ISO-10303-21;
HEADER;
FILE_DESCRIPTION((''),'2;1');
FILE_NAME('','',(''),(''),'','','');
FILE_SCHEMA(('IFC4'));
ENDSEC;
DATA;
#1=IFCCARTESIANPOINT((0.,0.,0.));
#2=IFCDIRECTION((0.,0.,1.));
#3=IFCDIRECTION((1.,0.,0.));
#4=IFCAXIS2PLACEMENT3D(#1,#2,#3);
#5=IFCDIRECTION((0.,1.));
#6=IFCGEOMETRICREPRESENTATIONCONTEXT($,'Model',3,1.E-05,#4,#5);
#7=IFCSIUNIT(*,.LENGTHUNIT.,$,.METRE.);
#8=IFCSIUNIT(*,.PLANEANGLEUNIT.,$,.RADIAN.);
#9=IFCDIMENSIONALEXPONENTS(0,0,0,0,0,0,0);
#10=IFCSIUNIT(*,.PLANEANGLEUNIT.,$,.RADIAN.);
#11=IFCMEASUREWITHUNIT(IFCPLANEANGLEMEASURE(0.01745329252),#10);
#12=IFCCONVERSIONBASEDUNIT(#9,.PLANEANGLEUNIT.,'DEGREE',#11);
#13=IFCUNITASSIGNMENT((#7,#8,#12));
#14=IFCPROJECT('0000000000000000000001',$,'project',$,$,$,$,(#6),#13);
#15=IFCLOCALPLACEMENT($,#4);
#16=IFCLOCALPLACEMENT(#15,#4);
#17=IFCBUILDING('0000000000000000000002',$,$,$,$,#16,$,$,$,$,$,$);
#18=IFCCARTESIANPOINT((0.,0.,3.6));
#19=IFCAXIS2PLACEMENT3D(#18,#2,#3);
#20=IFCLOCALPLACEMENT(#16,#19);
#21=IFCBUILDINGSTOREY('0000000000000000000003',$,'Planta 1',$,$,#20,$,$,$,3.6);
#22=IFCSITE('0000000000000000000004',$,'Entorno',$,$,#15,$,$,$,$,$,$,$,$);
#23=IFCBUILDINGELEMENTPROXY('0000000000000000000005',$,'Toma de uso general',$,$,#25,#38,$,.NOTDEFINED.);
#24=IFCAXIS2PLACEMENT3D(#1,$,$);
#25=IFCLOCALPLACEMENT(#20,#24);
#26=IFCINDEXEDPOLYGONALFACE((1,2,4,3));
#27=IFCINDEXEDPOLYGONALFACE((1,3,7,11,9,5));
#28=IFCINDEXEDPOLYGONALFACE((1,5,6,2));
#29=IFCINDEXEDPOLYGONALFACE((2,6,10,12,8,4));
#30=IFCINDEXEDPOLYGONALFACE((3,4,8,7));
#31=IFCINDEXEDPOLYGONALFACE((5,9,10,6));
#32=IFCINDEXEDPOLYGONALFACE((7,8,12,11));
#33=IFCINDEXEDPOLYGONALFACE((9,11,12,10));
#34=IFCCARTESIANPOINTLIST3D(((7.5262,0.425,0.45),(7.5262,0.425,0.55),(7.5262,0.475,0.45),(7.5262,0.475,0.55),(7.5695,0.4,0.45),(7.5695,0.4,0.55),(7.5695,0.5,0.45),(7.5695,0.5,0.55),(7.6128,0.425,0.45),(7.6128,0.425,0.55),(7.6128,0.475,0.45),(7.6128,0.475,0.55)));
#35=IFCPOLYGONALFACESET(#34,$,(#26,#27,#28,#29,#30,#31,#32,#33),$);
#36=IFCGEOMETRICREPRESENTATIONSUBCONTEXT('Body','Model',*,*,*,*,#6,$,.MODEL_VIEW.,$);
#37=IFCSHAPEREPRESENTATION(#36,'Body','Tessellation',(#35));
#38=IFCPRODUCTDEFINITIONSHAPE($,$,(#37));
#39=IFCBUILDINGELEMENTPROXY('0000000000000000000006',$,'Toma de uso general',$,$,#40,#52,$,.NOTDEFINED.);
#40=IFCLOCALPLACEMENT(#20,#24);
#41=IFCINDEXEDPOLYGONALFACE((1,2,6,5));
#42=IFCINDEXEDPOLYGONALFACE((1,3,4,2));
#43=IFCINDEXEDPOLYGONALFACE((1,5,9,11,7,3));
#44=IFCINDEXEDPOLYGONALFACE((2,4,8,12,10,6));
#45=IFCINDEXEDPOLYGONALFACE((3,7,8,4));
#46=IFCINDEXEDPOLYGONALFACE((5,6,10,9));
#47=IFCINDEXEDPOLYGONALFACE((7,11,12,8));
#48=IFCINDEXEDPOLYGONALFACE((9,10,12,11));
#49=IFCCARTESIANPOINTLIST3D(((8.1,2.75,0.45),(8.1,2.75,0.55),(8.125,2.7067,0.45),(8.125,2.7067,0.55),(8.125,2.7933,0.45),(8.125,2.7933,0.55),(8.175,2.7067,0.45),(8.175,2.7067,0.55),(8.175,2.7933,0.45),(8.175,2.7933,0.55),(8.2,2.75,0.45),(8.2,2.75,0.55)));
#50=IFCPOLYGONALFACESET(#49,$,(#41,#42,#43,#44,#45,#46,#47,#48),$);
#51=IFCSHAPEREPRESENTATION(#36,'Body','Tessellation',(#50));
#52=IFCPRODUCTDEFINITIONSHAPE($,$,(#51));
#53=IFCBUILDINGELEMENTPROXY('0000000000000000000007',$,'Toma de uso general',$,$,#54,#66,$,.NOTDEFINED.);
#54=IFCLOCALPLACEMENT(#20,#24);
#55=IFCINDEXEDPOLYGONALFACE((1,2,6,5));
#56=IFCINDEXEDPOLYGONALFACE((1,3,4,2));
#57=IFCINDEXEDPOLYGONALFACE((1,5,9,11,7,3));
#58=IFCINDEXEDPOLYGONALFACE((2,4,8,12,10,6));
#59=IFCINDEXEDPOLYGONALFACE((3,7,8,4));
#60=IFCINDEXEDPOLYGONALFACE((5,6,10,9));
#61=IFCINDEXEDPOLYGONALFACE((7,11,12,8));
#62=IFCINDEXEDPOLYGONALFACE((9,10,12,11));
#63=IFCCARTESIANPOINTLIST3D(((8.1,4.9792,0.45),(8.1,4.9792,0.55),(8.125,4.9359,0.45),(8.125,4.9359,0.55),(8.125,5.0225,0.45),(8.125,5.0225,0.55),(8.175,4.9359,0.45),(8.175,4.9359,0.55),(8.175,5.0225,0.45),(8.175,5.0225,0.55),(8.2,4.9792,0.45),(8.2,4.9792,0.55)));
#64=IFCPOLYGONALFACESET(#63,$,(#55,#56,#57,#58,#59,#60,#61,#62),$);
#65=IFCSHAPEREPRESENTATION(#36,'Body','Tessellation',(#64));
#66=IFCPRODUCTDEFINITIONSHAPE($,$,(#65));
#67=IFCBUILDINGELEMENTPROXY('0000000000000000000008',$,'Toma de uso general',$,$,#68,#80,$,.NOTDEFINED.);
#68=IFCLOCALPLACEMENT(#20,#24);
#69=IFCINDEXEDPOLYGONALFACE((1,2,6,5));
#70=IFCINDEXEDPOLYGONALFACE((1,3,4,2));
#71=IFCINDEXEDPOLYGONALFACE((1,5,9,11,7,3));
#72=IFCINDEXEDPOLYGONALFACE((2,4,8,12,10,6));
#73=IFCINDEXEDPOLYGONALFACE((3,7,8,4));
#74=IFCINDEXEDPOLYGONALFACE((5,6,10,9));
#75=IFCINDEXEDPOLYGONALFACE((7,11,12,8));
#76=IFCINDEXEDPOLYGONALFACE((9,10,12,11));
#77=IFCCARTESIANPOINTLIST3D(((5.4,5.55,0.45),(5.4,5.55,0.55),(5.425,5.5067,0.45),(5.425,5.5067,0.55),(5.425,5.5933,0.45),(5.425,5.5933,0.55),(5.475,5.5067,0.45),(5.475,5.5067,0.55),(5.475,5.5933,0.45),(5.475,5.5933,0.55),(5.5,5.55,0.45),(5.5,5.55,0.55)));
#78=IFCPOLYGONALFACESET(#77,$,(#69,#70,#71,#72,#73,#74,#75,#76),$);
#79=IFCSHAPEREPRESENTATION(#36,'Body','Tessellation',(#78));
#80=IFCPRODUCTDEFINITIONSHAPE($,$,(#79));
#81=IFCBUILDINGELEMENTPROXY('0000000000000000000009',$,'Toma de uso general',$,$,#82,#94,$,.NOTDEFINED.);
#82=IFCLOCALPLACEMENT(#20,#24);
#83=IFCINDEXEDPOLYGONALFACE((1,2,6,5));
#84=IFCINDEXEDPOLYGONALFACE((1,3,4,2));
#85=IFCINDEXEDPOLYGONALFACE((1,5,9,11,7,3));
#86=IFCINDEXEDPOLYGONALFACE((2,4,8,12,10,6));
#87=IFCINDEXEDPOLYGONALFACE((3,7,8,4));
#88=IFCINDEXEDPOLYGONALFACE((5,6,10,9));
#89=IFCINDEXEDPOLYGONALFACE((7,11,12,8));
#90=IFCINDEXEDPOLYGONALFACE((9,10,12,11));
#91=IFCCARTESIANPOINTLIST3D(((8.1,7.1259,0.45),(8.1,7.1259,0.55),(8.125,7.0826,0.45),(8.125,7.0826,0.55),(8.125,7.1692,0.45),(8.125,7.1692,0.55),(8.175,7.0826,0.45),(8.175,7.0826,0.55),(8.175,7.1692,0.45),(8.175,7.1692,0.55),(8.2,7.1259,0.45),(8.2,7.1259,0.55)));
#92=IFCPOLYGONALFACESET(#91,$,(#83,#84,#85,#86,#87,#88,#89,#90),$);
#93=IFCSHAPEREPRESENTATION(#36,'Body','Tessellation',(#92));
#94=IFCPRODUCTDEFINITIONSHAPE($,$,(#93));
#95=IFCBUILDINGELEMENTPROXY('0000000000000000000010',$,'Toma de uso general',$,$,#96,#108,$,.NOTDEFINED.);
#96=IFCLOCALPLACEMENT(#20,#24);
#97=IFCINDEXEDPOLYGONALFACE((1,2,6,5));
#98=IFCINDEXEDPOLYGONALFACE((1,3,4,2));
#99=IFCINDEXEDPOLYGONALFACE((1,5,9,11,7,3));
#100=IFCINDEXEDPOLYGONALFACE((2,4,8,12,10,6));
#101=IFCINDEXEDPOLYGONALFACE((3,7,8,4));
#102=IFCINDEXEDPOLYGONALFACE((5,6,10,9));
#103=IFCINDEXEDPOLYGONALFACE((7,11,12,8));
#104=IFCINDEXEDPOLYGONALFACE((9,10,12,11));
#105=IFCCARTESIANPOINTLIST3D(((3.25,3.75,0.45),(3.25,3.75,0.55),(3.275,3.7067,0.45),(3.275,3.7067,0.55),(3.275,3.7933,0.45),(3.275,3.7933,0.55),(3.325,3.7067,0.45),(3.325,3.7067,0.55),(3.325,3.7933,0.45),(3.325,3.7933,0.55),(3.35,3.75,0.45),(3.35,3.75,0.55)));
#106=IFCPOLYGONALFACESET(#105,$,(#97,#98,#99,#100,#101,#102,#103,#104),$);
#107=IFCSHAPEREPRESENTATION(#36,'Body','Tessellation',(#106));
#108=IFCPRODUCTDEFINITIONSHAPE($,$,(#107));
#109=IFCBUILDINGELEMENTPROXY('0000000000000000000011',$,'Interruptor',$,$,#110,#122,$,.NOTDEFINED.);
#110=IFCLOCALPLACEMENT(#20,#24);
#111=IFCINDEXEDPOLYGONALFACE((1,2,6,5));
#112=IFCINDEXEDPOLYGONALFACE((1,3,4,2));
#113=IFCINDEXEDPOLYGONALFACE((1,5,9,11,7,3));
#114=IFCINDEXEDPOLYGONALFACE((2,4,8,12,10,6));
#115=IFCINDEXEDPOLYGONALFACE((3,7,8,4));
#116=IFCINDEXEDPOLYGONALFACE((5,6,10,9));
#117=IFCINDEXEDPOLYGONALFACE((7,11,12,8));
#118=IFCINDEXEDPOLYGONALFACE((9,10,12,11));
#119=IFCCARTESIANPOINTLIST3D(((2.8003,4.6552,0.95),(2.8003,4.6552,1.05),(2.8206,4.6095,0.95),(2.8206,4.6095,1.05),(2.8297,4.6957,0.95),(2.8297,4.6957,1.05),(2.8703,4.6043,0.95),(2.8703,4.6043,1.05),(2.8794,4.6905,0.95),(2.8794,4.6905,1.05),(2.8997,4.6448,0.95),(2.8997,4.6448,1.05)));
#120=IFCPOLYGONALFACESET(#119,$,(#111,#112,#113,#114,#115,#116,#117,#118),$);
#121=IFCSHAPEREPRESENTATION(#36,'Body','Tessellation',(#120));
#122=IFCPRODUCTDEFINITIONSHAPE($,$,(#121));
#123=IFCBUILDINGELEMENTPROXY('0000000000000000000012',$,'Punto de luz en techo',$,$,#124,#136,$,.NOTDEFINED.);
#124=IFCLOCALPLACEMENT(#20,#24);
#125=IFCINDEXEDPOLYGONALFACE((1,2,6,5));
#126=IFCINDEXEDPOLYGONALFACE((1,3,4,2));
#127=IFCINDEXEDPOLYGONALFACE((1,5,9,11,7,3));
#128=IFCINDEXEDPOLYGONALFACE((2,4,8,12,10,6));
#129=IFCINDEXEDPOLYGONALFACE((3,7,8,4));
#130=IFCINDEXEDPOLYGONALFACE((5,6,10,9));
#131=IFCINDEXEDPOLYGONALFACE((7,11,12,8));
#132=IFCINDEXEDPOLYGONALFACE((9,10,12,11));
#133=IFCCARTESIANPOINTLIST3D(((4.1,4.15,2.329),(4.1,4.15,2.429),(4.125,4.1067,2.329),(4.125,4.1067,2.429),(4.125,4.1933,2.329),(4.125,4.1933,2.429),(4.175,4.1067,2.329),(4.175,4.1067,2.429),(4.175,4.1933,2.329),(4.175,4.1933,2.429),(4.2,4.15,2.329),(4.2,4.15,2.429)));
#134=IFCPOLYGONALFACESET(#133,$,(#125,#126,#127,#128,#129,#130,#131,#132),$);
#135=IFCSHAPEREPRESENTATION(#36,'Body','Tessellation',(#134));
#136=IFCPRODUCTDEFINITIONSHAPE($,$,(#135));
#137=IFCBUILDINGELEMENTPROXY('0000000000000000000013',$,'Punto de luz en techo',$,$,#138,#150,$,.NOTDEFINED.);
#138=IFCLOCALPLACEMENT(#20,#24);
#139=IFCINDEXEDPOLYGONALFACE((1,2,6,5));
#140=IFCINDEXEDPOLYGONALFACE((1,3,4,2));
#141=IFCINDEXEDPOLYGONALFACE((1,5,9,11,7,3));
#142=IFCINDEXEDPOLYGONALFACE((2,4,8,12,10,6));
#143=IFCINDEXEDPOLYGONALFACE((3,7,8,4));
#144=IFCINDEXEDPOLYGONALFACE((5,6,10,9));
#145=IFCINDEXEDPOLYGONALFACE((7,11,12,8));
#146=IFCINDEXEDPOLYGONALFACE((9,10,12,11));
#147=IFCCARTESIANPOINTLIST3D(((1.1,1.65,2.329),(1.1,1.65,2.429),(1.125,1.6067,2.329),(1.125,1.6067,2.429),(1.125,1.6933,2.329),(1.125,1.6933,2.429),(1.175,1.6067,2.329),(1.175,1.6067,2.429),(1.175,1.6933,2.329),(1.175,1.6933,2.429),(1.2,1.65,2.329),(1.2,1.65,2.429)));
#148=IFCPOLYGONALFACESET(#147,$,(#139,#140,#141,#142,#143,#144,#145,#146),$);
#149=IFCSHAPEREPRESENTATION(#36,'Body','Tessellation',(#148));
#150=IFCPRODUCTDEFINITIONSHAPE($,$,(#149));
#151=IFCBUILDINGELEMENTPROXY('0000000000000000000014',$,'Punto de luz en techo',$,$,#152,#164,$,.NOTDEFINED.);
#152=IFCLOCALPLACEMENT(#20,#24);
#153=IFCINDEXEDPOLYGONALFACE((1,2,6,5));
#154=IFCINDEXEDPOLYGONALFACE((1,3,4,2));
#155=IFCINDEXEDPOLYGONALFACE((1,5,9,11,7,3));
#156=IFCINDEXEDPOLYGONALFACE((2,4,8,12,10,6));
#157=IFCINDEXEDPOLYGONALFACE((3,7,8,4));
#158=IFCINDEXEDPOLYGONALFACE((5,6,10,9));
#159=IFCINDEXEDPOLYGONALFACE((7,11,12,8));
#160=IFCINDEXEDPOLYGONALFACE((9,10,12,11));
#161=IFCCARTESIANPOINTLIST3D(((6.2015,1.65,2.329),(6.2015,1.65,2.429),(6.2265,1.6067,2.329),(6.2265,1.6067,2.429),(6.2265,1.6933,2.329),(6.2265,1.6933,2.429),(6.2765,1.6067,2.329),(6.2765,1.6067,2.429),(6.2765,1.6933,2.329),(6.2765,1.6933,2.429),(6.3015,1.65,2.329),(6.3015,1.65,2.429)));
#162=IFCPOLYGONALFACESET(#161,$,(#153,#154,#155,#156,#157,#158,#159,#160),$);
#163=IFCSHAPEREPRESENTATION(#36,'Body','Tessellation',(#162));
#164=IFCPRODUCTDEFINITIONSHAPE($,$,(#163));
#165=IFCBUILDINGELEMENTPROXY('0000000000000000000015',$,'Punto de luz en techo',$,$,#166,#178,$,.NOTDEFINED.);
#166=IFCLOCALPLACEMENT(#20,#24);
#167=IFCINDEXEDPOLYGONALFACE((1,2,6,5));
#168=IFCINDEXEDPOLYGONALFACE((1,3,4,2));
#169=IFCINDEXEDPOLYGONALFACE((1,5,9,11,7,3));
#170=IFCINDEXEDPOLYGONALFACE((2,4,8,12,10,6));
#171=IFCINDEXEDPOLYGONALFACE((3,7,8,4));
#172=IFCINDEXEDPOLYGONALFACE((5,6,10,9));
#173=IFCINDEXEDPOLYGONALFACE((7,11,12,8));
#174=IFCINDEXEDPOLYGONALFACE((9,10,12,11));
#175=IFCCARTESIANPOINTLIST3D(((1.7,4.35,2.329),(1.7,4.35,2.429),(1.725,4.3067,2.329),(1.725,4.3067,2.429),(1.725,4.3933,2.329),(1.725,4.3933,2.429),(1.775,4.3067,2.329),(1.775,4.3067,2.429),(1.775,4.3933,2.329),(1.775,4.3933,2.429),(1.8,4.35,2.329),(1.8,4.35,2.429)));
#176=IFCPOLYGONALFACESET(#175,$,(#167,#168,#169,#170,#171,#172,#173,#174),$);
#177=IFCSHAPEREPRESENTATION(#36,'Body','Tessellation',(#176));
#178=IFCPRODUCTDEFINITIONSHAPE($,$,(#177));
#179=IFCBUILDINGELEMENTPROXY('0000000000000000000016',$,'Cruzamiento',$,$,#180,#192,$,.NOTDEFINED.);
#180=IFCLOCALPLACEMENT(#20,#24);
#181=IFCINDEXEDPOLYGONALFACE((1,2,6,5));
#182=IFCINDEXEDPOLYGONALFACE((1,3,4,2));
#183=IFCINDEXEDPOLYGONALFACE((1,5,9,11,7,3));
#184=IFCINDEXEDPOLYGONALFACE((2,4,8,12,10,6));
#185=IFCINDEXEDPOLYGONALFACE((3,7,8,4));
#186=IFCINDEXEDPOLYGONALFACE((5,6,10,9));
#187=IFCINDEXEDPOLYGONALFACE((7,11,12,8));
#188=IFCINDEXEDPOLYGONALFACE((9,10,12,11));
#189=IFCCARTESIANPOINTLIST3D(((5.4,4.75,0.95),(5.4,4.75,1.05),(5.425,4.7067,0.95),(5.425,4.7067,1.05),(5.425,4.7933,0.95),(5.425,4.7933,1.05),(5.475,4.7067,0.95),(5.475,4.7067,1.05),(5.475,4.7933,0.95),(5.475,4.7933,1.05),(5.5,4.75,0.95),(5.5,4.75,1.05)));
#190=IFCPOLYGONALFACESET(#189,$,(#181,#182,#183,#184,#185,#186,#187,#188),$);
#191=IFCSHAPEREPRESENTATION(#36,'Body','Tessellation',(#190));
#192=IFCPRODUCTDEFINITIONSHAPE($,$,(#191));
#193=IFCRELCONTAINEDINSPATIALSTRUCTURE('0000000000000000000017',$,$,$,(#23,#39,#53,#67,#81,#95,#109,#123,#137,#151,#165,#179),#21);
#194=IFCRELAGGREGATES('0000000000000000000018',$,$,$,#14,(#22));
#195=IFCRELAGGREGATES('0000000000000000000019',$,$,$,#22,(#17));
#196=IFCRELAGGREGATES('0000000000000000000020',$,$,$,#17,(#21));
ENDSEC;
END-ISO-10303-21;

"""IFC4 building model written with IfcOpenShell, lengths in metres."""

from ifc_helpers import new_model, entity, si_unit, converted_unit, direction, frame, origin_with_axes, place, context, subcontext, project, spatial, polyline, outline, extrude, source, transform, mapped, element, save


model = new_model("IFC4")

# Units and contexts
model_context = context("Model", 3, precision=1e-05, world=origin_with_axes(), true_north=direction((0.0, 1.0)))
body_context = subcontext(model_context, "Body", "Model", "MODEL_VIEW")
ifc_project = project(units=[si_unit("LENGTHUNIT", "METRE"), si_unit("PLANEANGLEUNIT", "RADIAN"), converted_unit("PLANEANGLEUNIT", "DEGREE", entity("IfcPlaneAngleMeasure", 0.01745329252), si_unit("PLANEANGLEUNIT", "RADIAN"), dimensions=[0, 0, 0, 0, 0, 0, 0])], contexts=[model_context])

# Site, building, storey
site_placement = place(None, origin_with_axes())
site = spatial("IfcSite", under=ifc_project, at=site_placement, Name="Entorno")
building_placement = place(site_placement, origin_with_axes())
building = spatial("IfcBuilding", under=site, at=building_placement)
storey_placement = place(building_placement, frame((0.0, 0.0, 3.6), z_axis=(0.0, 0.0, 1.0), x_axis=(1.0, 0.0, 0.0)))
storey = spatial("IfcBuildingStorey", under=building, at=storey_placement, Name="Planta 1", Elevation=3.6)

# Building element proxies
shared_shape_1 = source(origin_with_axes(), body_context, "Body", "SolidModel", [
    extrude(outline(polyline([(0.05, 0.0), (0.025, 0.0433), (-0.025, 0.0433), (-0.05, 0.0), (-0.025, -0.0433), (0.025, -0.0433), (0.05, 0.0)])), frame((0.0, 0.0, -0.05), z_axis=(0.0, 0.0, 1.0), x_axis=(1.0, 0.0, 0.0)), (0.0, 0.0, 1.0), 0.1),
])
proxy_1_placement = place(storey_placement, frame((0.0, 0.0, -3.6), z_axis=(0.0, 0.0, 1.0), x_axis=(1.0, 0.0, 0.0)))
element("IfcBuildingElementProxy", 1, at=proxy_1_placement, inside=storey, Name="Toma de uso general", PredefinedType="NOTDEFINED", context=body_context, shape_type="Brep", body=[
    mapped(shared_shape_1, transform((7.5695, 0.45, 4.1), x_axis=(0.0, 1.0, 0.0), y_axis=(-1.0, 0.0, 0.0), z_axis=(0.0, 0.0, 1.0))),
])
proxy_2_placement = place(storey_placement, frame((0.0, 0.0, -3.6), z_axis=(0.0, 0.0, 1.0), x_axis=(1.0, 0.0, 0.0)))
element("IfcBuildingElementProxy", 2, at=proxy_2_placement, inside=storey, Name="Toma de uso general", PredefinedType="NOTDEFINED", context=body_context, shape_type="Brep", body=[
    mapped(shared_shape_1, transform((8.15, 2.75, 4.1), x_axis=(-1.0, 0.0, 0.0), y_axis=(0.0, -1.0, 0.0), z_axis=(0.0, 0.0, 1.0))),
])
proxy_3_placement = place(storey_placement, frame((0.0, 0.0, -3.6), z_axis=(0.0, 0.0, 1.0), x_axis=(1.0, 0.0, 0.0)))
element("IfcBuildingElementProxy", 3, at=proxy_3_placement, inside=storey, Name="Toma de uso general", PredefinedType="NOTDEFINED", context=body_context, shape_type="Brep", body=[
    mapped(shared_shape_1, transform((8.15, 4.9792, 4.1), x_axis=(-1.0, 0.0, 0.0), y_axis=(0.0, -1.0, 0.0), z_axis=(0.0, 0.0, 1.0))),
])
proxy_4_placement = place(storey_placement, frame((0.0, 0.0, -3.6), z_axis=(0.0, 0.0, 1.0), x_axis=(1.0, 0.0, 0.0)))
element("IfcBuildingElementProxy", 4, at=proxy_4_placement, inside=storey, Name="Toma de uso general", PredefinedType="NOTDEFINED", context=body_context, shape_type="Brep", body=[
    mapped(shared_shape_1, transform((5.45, 5.55, 4.1), x_axis=(1.0, 0.0, 0.0), y_axis=(0.0, 1.0, 0.0), z_axis=(0.0, 0.0, 1.0))),
])
proxy_5_placement = place(storey_placement, frame((0.0, 0.0, -3.6), z_axis=(0.0, 0.0, 1.0), x_axis=(1.0, 0.0, 0.0)))
element("IfcBuildingElementProxy", 5, at=proxy_5_placement, inside=storey, Name="Toma de uso general", PredefinedType="NOTDEFINED", context=body_context, shape_type="Brep", body=[
    mapped(shared_shape_1, transform((8.15, 7.1259, 4.1), x_axis=(-1.0, 0.0, 0.0), y_axis=(0.0, -1.0, 0.0), z_axis=(0.0, 0.0, 1.0))),
])
proxy_6_placement = place(storey_placement, frame((0.0, 0.0, -3.6), z_axis=(0.0, 0.0, 1.0), x_axis=(1.0, 0.0, 0.0)))
element("IfcBuildingElementProxy", 6, at=proxy_6_placement, inside=storey, Name="Toma de uso general", PredefinedType="NOTDEFINED", context=body_context, shape_type="Brep", body=[
    mapped(shared_shape_1, transform((3.3, 3.75, 4.1), x_axis=(1.0, 0.0, 0.0), y_axis=(0.0, 1.0, 0.0), z_axis=(0.0, 0.0, 1.0))),
])
shared_shape_2 = source(origin_with_axes(), body_context, "Body", "SolidModel", [
    extrude(outline(polyline([(0.05, 0.0), (0.025, 0.0433), (-0.025, 0.0433), (-0.05, 0.0), (-0.025, -0.0433), (0.025, -0.0433), (0.05, 0.0)])), frame((0.0, 0.0, -0.05), z_axis=(0.0, 0.0, 1.0), x_axis=(1.0, 0.0, 0.0)), (0.0, 0.0, 1.0), 0.1),
])
proxy_7_placement = place(storey_placement, frame((0.0, 0.0, -3.6), z_axis=(0.0, 0.0, 1.0), x_axis=(1.0, 0.0, 0.0)))
element("IfcBuildingElementProxy", 7, at=proxy_7_placement, inside=storey, Name="Interruptor", PredefinedType="NOTDEFINED", context=body_context, shape_type="Brep", body=[
    mapped(shared_shape_2, transform((2.85, 4.65, 4.6), x_axis=(-0.406737, 0.913545, 0.0), y_axis=(-0.913545, -0.406737, 0.0), z_axis=(0.0, 0.0, 1.0))),
])
shared_shape_3 = source(origin_with_axes(), body_context, "Body", "SolidModel", [
    extrude(outline(polyline([(0.05, 0.0), (0.025, 0.0433), (-0.025, 0.0433), (-0.05, 0.0), (-0.025, -0.0433), (0.025, -0.0433), (0.05, 0.0)])), frame((0.0, 0.0, -0.05), z_axis=(0.0, 0.0, 1.0), x_axis=(1.0, 0.0, 0.0)), (0.0, 0.0, 1.0), 0.1),
])
proxy_8_placement = place(storey_placement, frame((0.0, 0.0, -3.6), z_axis=(0.0, 0.0, 1.0), x_axis=(1.0, 0.0, 0.0)))
element("IfcBuildingElementProxy", 8, at=proxy_8_placement, inside=storey, Name="Punto de luz en techo", PredefinedType="NOTDEFINED", context=body_context, shape_type="Brep", body=[
    mapped(shared_shape_3, transform((4.15, 4.15, 5.979), x_axis=(1.0, 0.0, 0.0), y_axis=(0.0, 1.0, 0.0), z_axis=(0.0, 0.0, 1.0))),
])
proxy_9_placement = place(storey_placement, frame((0.0, 0.0, -3.6), z_axis=(0.0, 0.0, 1.0), x_axis=(1.0, 0.0, 0.0)))
element("IfcBuildingElementProxy", 9, at=proxy_9_placement, inside=storey, Name="Punto de luz en techo", PredefinedType="NOTDEFINED", context=body_context, shape_type="Brep", body=[
    mapped(shared_shape_3, transform((1.15, 1.65, 5.979), x_axis=(1.0, 0.0, 0.0), y_axis=(0.0, 1.0, 0.0), z_axis=(0.0, 0.0, 1.0))),
])
proxy_10_placement = place(storey_placement, frame((0.0, 0.0, -3.6), z_axis=(0.0, 0.0, 1.0), x_axis=(1.0, 0.0, 0.0)))
element("IfcBuildingElementProxy", 10, at=proxy_10_placement, inside=storey, Name="Punto de luz en techo", PredefinedType="NOTDEFINED", context=body_context, shape_type="Brep", body=[
    mapped(shared_shape_3, transform((6.2515, 1.65, 5.979), x_axis=(1.0, 0.0, 0.0), y_axis=(0.0, 1.0, 0.0), z_axis=(0.0, 0.0, 1.0))),
])
proxy_11_placement = place(storey_placement, frame((0.0, 0.0, -3.6), z_axis=(0.0, 0.0, 1.0), x_axis=(1.0, 0.0, 0.0)))
element("IfcBuildingElementProxy", 11, at=proxy_11_placement, inside=storey, Name="Punto de luz en techo", PredefinedType="NOTDEFINED", context=body_context, shape_type="Brep", body=[
    mapped(shared_shape_3, transform((1.75, 4.35, 5.979), x_axis=(-1.0, 0.0, 0.0), y_axis=(0.0, -1.0, 0.0), z_axis=(0.0, 0.0, 1.0))),
])
shared_shape_4 = source(origin_with_axes(), body_context, "Body", "SolidModel", [
    extrude(outline(polyline([(0.05, 0.0), (0.025, 0.0433), (-0.025, 0.0433), (-0.05, 0.0), (-0.025, -0.0433), (0.025, -0.0433), (0.05, 0.0)])), frame((0.0, 0.0, -0.05), z_axis=(0.0, 0.0, 1.0), x_axis=(1.0, 0.0, 0.0)), (0.0, 0.0, 1.0), 0.1),
])
proxy_12_placement = place(storey_placement, frame((0.0, 0.0, -3.6), z_axis=(0.0, 0.0, 1.0), x_axis=(1.0, 0.0, 0.0)))
element("IfcBuildingElementProxy", 12, at=proxy_12_placement, inside=storey, Name="Cruzamiento", PredefinedType="NOTDEFINED", context=body_context, shape_type="Brep", body=[
    mapped(shared_shape_4, transform((5.45, 4.75, 4.6), x_axis=(1.0, 0.0, 0.0), y_axis=(0.0, 1.0, 0.0), z_axis=(0.0, 0.0, 1.0))),
])

save(model, "model.ifc")
